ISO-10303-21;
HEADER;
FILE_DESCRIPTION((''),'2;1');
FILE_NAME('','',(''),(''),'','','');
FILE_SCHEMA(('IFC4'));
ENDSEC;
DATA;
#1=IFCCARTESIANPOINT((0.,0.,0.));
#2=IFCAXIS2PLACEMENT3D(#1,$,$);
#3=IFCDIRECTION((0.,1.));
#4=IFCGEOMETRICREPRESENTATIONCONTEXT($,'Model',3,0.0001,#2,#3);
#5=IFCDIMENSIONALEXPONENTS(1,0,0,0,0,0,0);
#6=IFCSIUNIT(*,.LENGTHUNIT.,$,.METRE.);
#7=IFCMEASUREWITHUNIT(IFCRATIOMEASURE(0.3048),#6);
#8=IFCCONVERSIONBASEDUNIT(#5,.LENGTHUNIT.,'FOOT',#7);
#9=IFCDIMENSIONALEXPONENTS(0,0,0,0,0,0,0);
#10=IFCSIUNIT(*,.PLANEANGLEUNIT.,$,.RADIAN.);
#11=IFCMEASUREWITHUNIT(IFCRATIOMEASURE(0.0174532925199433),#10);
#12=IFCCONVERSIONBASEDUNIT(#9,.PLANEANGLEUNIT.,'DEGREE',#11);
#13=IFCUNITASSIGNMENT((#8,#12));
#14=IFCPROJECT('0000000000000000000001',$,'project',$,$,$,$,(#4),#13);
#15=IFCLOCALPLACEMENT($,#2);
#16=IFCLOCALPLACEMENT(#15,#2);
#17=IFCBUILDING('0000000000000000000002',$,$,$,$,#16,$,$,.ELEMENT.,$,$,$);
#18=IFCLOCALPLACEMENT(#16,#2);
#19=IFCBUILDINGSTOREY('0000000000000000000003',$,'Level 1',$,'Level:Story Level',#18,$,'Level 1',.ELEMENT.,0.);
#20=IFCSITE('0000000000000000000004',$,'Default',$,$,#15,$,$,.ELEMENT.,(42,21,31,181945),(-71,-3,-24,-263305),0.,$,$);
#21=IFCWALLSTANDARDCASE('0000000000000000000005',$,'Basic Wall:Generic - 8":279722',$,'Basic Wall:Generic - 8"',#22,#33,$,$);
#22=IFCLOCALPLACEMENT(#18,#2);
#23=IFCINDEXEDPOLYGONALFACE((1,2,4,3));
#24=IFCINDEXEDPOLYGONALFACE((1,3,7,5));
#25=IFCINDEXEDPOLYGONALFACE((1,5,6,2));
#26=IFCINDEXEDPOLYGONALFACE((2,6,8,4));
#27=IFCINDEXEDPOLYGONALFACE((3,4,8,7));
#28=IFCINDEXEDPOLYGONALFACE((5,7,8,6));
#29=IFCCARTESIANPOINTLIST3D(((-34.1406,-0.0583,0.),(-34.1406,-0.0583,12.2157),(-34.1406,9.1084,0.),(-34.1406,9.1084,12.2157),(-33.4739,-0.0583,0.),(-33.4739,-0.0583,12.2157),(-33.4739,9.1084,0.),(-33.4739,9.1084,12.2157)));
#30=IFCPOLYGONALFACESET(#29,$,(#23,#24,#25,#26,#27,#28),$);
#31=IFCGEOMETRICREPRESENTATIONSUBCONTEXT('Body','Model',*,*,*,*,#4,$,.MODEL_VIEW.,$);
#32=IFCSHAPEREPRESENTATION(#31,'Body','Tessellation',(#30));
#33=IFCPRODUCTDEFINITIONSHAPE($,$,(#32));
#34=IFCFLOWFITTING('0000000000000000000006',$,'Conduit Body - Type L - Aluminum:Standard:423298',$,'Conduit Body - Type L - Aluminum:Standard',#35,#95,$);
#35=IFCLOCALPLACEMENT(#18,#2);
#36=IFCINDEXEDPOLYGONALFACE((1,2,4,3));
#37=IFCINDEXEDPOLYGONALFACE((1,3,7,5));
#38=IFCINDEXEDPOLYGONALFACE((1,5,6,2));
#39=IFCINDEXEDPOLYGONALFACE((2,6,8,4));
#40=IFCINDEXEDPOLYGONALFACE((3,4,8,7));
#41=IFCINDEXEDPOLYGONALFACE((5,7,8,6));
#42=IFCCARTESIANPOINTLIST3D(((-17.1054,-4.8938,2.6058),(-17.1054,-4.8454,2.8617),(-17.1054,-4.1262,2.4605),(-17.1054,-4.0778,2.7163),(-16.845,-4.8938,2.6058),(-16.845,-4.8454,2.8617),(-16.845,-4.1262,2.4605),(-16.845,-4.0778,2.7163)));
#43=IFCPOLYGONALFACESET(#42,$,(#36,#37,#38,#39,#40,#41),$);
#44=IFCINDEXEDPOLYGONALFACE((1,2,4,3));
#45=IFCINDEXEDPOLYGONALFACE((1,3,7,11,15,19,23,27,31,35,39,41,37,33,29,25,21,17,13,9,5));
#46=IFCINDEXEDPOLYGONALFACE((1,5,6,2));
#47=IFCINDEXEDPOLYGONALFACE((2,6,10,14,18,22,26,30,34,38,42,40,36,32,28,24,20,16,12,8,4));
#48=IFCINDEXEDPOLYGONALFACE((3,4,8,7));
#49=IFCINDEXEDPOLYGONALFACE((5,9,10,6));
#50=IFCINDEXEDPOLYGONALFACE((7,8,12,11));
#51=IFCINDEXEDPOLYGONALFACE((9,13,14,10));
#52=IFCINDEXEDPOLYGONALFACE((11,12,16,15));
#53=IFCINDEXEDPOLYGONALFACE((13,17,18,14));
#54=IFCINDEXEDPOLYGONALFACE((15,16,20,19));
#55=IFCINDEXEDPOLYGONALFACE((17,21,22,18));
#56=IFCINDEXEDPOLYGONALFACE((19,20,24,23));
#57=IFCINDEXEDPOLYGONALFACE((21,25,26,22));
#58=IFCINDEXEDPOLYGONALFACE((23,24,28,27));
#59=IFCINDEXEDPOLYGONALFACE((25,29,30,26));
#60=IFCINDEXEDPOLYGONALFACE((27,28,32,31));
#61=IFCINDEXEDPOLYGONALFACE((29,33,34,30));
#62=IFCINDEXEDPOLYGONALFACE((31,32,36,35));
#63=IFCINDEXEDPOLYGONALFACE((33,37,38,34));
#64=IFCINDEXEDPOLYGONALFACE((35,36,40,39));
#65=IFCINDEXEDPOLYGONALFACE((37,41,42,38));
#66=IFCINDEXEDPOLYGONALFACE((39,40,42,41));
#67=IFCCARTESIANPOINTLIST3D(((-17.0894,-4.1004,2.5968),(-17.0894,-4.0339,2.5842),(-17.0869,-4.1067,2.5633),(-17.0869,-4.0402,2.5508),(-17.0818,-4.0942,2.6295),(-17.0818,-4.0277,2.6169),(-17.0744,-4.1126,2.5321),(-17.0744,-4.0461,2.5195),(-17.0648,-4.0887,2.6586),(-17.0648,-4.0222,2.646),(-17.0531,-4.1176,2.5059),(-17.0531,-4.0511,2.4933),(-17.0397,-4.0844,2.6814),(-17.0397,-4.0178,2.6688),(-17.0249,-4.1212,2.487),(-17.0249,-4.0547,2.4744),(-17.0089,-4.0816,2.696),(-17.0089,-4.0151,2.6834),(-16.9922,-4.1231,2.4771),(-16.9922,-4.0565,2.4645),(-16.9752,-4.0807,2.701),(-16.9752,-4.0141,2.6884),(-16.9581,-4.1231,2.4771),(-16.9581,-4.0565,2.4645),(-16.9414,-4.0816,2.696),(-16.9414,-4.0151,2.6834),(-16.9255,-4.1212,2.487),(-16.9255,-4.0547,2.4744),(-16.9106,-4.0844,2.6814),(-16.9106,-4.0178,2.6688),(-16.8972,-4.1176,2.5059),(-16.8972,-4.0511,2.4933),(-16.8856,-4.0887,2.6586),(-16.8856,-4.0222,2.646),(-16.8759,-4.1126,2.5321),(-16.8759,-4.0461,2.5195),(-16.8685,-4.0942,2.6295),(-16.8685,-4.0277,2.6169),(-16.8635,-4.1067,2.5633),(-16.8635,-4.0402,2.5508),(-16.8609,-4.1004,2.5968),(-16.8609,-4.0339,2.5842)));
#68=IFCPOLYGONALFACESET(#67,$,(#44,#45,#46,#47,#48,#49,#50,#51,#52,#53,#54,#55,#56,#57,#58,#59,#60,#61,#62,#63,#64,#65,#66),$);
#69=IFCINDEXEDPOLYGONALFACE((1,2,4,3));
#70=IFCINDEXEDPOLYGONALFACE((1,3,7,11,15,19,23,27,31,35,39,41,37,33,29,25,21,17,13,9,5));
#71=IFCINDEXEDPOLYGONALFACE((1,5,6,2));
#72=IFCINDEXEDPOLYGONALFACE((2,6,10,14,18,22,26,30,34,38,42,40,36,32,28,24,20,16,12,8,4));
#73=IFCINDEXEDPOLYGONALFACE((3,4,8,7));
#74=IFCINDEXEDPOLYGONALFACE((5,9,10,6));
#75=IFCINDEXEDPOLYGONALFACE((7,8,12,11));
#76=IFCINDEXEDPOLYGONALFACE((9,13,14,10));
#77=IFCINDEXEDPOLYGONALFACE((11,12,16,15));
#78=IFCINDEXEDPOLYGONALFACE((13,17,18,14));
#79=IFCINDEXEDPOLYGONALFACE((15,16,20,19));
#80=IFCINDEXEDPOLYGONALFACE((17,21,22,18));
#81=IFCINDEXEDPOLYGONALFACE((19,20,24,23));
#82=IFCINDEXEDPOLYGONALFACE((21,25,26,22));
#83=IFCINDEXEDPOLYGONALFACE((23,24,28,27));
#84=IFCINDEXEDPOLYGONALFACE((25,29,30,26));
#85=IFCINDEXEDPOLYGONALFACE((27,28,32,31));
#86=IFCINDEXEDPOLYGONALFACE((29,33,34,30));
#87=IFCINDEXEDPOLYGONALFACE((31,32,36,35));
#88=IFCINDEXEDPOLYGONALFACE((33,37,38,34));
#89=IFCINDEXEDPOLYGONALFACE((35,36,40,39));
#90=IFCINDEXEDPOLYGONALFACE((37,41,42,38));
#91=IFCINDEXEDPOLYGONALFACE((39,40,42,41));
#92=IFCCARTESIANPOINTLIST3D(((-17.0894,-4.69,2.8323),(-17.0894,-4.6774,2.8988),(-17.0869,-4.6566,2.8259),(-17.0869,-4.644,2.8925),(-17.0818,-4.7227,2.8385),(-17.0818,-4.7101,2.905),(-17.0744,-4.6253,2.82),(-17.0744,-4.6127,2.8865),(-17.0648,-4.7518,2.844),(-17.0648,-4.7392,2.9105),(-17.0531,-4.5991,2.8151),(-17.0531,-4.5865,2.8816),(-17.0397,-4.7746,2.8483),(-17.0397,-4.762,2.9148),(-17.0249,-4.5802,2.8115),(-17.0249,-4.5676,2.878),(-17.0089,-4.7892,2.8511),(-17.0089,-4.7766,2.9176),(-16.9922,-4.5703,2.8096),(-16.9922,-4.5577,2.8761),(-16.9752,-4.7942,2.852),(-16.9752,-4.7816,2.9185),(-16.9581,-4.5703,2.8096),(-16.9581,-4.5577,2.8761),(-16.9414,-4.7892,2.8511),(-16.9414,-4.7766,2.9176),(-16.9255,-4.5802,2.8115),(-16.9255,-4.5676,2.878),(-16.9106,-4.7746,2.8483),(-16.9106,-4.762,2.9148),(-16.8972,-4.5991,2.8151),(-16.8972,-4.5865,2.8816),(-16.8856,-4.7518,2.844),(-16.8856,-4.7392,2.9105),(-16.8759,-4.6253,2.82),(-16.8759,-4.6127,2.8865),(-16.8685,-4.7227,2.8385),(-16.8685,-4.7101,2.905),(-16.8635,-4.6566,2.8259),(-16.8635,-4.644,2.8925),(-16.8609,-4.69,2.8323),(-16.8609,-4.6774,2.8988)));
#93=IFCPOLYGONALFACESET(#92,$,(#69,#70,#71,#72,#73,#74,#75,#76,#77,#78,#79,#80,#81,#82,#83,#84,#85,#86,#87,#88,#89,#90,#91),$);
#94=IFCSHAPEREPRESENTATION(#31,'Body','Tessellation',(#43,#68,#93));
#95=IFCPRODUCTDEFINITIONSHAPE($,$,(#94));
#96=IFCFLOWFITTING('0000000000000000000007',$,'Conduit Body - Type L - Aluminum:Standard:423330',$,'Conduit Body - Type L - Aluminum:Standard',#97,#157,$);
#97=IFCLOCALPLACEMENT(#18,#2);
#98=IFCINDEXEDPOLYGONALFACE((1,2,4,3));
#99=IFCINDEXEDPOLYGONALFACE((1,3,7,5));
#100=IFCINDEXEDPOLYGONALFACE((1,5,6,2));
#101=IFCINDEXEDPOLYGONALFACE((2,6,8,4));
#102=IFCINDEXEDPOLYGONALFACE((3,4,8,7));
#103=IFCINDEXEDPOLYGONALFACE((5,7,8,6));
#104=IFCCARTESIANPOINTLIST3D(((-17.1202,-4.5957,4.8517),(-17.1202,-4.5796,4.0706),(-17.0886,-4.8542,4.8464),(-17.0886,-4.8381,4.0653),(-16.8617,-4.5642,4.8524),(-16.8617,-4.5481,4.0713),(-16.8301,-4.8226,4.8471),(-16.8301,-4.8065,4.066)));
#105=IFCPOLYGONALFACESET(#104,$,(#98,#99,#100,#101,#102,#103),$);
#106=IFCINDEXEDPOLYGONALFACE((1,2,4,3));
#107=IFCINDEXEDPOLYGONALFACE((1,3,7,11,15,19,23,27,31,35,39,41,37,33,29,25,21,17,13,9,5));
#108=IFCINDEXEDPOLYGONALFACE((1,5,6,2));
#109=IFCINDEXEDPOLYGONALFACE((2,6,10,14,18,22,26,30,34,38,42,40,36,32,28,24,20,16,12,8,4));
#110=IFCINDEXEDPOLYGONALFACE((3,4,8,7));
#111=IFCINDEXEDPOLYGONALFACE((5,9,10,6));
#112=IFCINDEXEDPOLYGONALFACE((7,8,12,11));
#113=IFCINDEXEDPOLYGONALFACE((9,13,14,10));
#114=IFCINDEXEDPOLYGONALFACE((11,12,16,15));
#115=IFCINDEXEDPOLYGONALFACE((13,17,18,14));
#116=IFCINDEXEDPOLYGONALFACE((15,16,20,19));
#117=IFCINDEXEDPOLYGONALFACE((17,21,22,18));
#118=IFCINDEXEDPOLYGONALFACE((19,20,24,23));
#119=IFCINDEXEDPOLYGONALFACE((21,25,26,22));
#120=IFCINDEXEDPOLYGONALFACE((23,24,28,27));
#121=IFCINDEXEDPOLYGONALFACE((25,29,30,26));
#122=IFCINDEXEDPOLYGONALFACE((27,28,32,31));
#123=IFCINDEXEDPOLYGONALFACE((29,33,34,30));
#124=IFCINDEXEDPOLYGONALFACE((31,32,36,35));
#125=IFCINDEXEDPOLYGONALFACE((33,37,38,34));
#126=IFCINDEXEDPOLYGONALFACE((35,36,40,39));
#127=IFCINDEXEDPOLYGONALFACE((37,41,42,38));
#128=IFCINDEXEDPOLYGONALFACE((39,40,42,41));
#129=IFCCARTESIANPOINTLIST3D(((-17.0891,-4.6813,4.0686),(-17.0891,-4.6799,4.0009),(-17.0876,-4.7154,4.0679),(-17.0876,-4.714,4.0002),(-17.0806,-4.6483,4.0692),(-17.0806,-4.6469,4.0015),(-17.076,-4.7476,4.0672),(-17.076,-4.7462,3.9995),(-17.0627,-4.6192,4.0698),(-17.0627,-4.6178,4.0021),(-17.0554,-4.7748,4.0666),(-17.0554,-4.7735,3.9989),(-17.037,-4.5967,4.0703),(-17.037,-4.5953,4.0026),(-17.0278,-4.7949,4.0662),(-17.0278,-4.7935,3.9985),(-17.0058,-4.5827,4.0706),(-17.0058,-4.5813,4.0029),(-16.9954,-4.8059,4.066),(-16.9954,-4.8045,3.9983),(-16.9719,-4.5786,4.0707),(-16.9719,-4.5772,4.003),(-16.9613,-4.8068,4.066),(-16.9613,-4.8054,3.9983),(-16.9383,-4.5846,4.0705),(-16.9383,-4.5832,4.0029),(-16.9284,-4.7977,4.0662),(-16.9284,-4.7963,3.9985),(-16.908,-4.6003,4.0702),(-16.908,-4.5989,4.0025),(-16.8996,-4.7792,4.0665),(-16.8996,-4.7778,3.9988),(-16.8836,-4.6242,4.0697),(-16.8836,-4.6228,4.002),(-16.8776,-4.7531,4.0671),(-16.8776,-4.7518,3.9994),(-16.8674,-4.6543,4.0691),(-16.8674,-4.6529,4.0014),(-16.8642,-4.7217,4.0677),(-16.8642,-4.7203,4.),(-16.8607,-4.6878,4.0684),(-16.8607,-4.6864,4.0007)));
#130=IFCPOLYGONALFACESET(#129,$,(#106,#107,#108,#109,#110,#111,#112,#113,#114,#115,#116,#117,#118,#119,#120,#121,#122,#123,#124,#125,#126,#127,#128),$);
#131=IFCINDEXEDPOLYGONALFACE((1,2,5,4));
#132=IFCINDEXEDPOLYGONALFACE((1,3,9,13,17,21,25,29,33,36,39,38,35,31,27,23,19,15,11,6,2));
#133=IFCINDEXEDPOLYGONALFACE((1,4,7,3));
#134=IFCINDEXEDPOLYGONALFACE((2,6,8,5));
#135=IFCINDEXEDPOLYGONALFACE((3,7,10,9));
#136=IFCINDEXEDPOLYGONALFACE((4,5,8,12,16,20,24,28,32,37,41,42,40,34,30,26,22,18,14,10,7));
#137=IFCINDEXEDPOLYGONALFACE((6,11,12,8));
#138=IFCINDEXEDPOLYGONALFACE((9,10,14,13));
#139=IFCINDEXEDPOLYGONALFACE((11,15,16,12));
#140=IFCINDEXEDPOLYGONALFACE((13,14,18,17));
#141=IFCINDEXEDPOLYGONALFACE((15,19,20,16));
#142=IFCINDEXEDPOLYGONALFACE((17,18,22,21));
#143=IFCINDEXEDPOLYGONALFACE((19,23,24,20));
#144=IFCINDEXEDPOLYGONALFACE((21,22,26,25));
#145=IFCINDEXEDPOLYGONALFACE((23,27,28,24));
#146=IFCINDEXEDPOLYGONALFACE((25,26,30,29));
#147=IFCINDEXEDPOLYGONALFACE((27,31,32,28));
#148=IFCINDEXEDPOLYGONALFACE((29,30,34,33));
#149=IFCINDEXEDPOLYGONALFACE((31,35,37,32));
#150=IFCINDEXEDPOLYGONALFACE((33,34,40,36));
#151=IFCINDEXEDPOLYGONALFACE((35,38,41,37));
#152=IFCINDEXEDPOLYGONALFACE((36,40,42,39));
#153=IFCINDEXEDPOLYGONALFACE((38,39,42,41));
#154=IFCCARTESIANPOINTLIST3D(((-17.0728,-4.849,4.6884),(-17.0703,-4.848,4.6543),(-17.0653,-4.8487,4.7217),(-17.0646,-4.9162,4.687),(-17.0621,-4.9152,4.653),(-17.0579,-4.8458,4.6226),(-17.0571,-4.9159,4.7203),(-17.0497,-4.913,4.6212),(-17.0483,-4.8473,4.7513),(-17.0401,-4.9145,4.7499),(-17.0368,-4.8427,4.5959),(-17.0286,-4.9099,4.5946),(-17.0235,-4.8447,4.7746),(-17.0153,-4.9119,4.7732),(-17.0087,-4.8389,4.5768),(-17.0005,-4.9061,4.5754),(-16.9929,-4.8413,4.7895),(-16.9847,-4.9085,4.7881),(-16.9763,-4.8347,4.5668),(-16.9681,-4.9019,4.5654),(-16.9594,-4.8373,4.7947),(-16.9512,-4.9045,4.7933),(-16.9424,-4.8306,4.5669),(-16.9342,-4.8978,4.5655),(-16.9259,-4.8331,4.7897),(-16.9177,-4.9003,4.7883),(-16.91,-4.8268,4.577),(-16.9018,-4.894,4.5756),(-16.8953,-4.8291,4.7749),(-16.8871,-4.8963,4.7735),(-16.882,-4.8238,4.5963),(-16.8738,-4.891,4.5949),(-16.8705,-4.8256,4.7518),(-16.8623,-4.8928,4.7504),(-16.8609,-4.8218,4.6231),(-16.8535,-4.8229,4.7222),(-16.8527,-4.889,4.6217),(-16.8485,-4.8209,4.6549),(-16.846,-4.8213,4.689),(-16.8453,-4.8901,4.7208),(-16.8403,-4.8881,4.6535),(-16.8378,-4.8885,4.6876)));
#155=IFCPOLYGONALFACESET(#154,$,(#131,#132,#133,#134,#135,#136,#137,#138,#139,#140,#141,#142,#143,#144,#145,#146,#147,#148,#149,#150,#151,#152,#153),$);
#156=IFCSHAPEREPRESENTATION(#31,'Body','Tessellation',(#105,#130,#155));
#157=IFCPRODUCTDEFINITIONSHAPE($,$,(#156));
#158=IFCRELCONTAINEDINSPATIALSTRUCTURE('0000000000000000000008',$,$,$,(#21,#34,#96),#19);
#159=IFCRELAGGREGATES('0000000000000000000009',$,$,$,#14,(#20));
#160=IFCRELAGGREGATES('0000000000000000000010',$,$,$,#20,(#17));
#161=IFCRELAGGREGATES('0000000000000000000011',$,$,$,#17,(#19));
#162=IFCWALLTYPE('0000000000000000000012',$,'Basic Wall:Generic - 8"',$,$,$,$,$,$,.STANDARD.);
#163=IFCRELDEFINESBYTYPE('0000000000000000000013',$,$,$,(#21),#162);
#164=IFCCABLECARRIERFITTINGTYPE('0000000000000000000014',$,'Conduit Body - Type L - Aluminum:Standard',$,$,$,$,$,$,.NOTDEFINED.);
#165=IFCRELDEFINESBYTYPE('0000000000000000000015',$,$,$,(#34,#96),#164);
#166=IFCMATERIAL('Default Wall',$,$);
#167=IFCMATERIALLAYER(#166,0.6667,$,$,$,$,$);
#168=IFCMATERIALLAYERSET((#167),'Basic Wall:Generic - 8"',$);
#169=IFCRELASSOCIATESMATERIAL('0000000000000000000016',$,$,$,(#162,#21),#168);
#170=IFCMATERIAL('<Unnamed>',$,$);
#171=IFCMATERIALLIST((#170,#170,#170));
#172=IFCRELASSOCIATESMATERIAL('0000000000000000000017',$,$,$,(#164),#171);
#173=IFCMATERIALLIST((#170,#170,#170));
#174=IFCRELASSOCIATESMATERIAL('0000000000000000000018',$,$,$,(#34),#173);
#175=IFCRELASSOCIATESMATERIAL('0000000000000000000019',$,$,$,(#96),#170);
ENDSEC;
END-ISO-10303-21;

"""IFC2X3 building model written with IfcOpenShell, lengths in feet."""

from ifc_helpers import new_model, entity, si_unit, converted_unit, direction, frame, frame_2d, origin, place, context, subcontext, project, spatial, rectangle, circle, extrude, source, transform, mapped, material, material_list, layer, layer_set, layer_usage, type_object, type_shapes, element, save


model = new_model("IFC2X3")

# Units and contexts
model_context = context("Model", 3, precision=0.0001, world=origin(), true_north=direction((0.0, 1.0)))
body_context = subcontext(model_context, "Body", "Model", "MODEL_VIEW")
ifc_project = project(units=[converted_unit("LENGTHUNIT", "FOOT", entity("IfcRatioMeasure", 0.3048), si_unit("LENGTHUNIT", "METRE"), dimensions=[1, 0, 0, 0, 0, 0, 0]), converted_unit("PLANEANGLEUNIT", "DEGREE", entity("IfcRatioMeasure", 0.0174532925199433), si_unit("PLANEANGLEUNIT", "RADIAN"), dimensions=[0, 0, 0, 0, 0, 0, 0])], contexts=[model_context])

# Site, building, storey
site_placement = place(None, origin())
site = spatial("IfcSite", under=ifc_project, at=site_placement, Name="Default", CompositionType="ELEMENT", RefLatitude=(42, 21, 31, 181945), RefLongitude=(-71, -3, -24, -263305), RefElevation=0.0)
building_placement = place(site_placement, origin())
building = spatial("IfcBuilding", under=site, at=building_placement, CompositionType="ELEMENT")
storey_placement = place(building_placement, origin())
storey = spatial("IfcBuildingStorey", under=building, at=storey_placement, Name="Level 1", ObjectType="Level:Story Level", LongName="Level 1", CompositionType="ELEMENT", Elevation=0.0)

# Wall
ifc_material_1 = material(Name="Default Wall")
ifc_layer = layer(ifc_material_1, 0.6667)
ifc_layer_set = layer_set([ifc_layer], Name="Basic Wall:Generic - 8\"")
wall_type = type_object("IfcWallType", Name="Basic Wall:Generic - 8\"", PredefinedType="STANDARD", material=ifc_layer_set)
ifc_layer_usage_1 = layer_usage(ifc_layer_set, "AXIS2", "NEGATIVE", 0.3333)
wall_1_placement = place(storey_placement, frame((-33.8073, -0.0583, 0.0), z_axis=(0.0, 0.0, 1.0), x_axis=(0.0, 1.0, 0.0)))
element("IfcWallStandardCase", 1, at=wall_1_placement, inside=storey, type_object=wall_type, material=ifc_layer_usage_1, Name="Basic Wall:Generic - 8\":279722", ObjectType="Basic Wall:Generic - 8\"", context=body_context, shape_type="SweptSolid", body=[
    extrude(rectangle(XDim=9.1667, YDim=0.6667, at=frame_2d((4.5833, 0.0), x_axis=(-1.0, 0.0))), origin(), (0.0, 0.0, 1.0), 12.2157),
])

# Shared definitions
ifc_material_2 = material(Name="<Unnamed>")

# Flow fittings
ifc_material_list_1 = material_list([ifc_material_2, ifc_material_2, ifc_material_2])
ifc_material_list_2 = material_list([ifc_material_2, ifc_material_2, ifc_material_2])
cable_carrier_fitting_type = type_object("IfcCableCarrierFittingType", Name="Conduit Body - Type L - Aluminum:Standard", PredefinedType="NOTDEFINED", material=ifc_material_list_2)
shared_shape_1 = source(origin(), body_context, "Body", "SweptSolid", [
    extrude(rectangle(XDim=0.7812, YDim=0.2604, at=frame_2d((0.0, 0.0), x_axis=(1.0, 0.0))), frame((-0.224, 0.0, -0.1302), z_axis=(0.0, 0.0, 1.0), x_axis=(-1.0, 0.0, 0.0)), (0.0, 0.0, 1.0), 0.2604),
    extrude(circle(Radius=0.1146, at=frame_2d((0.0, 0.0), x_axis=(1.0, 0.0))), frame((-0.6823, 0.0, 0.0), z_axis=(1.0, 0.0, 0.0), x_axis=(0.0, 1.0, 0.0)), (0.0, 0.0, 1.0), 0.0677),
    extrude(circle(Radius=0.1146, at=frame_2d((0.0, 0.0), x_axis=(1.0, 0.0))), frame((0.0, 0.1302, 0.0), z_axis=(0.0, 1.0, 0.0), x_axis=(1.0, 0.0, 0.0)), (0.0, 0.0, 1.0), 0.0677),
])
type_shapes(cable_carrier_fitting_type, [shared_shape_1])
flow_fitting_1_placement = place(storey_placement, frame((-16.9752, -4.7058, 2.7027), z_axis=(-1.0, 0.0, 0.0), x_axis=(0.0, -0.982539, 0.186057)))
element("IfcFlowFitting", 2, at=flow_fitting_1_placement, inside=storey, type_object=cable_carrier_fitting_type, material=ifc_material_list_1, Name="Conduit Body - Type L - Aluminum:Standard:423298", ObjectType="Conduit Body - Type L - Aluminum:Standard", context=body_context, shape_type="MappedRepresentation", body=[
    mapped(shared_shape_1, transform((0.0, 0.0, 0.0), scale=1.0)),
])
flow_fitting_2_placement = place(storey_placement, frame((-16.9752, -4.7057, 4.6828), z_axis=(0.992636, 0.121109, 0.002491), x_axis=(0.0, -0.020568, 0.999788)))
element("IfcFlowFitting", 3, at=flow_fitting_2_placement, inside=storey, type_object=cable_carrier_fitting_type, material=ifc_material_2, Name="Conduit Body - Type L - Aluminum:Standard:423330", ObjectType="Conduit Body - Type L - Aluminum:Standard", context=body_context, shape_type="MappedRepresentation", body=[
    mapped(shared_shape_1, transform((0.0, 0.0, 0.0), scale=1.0)),
])

save(model, "model.ifc")
